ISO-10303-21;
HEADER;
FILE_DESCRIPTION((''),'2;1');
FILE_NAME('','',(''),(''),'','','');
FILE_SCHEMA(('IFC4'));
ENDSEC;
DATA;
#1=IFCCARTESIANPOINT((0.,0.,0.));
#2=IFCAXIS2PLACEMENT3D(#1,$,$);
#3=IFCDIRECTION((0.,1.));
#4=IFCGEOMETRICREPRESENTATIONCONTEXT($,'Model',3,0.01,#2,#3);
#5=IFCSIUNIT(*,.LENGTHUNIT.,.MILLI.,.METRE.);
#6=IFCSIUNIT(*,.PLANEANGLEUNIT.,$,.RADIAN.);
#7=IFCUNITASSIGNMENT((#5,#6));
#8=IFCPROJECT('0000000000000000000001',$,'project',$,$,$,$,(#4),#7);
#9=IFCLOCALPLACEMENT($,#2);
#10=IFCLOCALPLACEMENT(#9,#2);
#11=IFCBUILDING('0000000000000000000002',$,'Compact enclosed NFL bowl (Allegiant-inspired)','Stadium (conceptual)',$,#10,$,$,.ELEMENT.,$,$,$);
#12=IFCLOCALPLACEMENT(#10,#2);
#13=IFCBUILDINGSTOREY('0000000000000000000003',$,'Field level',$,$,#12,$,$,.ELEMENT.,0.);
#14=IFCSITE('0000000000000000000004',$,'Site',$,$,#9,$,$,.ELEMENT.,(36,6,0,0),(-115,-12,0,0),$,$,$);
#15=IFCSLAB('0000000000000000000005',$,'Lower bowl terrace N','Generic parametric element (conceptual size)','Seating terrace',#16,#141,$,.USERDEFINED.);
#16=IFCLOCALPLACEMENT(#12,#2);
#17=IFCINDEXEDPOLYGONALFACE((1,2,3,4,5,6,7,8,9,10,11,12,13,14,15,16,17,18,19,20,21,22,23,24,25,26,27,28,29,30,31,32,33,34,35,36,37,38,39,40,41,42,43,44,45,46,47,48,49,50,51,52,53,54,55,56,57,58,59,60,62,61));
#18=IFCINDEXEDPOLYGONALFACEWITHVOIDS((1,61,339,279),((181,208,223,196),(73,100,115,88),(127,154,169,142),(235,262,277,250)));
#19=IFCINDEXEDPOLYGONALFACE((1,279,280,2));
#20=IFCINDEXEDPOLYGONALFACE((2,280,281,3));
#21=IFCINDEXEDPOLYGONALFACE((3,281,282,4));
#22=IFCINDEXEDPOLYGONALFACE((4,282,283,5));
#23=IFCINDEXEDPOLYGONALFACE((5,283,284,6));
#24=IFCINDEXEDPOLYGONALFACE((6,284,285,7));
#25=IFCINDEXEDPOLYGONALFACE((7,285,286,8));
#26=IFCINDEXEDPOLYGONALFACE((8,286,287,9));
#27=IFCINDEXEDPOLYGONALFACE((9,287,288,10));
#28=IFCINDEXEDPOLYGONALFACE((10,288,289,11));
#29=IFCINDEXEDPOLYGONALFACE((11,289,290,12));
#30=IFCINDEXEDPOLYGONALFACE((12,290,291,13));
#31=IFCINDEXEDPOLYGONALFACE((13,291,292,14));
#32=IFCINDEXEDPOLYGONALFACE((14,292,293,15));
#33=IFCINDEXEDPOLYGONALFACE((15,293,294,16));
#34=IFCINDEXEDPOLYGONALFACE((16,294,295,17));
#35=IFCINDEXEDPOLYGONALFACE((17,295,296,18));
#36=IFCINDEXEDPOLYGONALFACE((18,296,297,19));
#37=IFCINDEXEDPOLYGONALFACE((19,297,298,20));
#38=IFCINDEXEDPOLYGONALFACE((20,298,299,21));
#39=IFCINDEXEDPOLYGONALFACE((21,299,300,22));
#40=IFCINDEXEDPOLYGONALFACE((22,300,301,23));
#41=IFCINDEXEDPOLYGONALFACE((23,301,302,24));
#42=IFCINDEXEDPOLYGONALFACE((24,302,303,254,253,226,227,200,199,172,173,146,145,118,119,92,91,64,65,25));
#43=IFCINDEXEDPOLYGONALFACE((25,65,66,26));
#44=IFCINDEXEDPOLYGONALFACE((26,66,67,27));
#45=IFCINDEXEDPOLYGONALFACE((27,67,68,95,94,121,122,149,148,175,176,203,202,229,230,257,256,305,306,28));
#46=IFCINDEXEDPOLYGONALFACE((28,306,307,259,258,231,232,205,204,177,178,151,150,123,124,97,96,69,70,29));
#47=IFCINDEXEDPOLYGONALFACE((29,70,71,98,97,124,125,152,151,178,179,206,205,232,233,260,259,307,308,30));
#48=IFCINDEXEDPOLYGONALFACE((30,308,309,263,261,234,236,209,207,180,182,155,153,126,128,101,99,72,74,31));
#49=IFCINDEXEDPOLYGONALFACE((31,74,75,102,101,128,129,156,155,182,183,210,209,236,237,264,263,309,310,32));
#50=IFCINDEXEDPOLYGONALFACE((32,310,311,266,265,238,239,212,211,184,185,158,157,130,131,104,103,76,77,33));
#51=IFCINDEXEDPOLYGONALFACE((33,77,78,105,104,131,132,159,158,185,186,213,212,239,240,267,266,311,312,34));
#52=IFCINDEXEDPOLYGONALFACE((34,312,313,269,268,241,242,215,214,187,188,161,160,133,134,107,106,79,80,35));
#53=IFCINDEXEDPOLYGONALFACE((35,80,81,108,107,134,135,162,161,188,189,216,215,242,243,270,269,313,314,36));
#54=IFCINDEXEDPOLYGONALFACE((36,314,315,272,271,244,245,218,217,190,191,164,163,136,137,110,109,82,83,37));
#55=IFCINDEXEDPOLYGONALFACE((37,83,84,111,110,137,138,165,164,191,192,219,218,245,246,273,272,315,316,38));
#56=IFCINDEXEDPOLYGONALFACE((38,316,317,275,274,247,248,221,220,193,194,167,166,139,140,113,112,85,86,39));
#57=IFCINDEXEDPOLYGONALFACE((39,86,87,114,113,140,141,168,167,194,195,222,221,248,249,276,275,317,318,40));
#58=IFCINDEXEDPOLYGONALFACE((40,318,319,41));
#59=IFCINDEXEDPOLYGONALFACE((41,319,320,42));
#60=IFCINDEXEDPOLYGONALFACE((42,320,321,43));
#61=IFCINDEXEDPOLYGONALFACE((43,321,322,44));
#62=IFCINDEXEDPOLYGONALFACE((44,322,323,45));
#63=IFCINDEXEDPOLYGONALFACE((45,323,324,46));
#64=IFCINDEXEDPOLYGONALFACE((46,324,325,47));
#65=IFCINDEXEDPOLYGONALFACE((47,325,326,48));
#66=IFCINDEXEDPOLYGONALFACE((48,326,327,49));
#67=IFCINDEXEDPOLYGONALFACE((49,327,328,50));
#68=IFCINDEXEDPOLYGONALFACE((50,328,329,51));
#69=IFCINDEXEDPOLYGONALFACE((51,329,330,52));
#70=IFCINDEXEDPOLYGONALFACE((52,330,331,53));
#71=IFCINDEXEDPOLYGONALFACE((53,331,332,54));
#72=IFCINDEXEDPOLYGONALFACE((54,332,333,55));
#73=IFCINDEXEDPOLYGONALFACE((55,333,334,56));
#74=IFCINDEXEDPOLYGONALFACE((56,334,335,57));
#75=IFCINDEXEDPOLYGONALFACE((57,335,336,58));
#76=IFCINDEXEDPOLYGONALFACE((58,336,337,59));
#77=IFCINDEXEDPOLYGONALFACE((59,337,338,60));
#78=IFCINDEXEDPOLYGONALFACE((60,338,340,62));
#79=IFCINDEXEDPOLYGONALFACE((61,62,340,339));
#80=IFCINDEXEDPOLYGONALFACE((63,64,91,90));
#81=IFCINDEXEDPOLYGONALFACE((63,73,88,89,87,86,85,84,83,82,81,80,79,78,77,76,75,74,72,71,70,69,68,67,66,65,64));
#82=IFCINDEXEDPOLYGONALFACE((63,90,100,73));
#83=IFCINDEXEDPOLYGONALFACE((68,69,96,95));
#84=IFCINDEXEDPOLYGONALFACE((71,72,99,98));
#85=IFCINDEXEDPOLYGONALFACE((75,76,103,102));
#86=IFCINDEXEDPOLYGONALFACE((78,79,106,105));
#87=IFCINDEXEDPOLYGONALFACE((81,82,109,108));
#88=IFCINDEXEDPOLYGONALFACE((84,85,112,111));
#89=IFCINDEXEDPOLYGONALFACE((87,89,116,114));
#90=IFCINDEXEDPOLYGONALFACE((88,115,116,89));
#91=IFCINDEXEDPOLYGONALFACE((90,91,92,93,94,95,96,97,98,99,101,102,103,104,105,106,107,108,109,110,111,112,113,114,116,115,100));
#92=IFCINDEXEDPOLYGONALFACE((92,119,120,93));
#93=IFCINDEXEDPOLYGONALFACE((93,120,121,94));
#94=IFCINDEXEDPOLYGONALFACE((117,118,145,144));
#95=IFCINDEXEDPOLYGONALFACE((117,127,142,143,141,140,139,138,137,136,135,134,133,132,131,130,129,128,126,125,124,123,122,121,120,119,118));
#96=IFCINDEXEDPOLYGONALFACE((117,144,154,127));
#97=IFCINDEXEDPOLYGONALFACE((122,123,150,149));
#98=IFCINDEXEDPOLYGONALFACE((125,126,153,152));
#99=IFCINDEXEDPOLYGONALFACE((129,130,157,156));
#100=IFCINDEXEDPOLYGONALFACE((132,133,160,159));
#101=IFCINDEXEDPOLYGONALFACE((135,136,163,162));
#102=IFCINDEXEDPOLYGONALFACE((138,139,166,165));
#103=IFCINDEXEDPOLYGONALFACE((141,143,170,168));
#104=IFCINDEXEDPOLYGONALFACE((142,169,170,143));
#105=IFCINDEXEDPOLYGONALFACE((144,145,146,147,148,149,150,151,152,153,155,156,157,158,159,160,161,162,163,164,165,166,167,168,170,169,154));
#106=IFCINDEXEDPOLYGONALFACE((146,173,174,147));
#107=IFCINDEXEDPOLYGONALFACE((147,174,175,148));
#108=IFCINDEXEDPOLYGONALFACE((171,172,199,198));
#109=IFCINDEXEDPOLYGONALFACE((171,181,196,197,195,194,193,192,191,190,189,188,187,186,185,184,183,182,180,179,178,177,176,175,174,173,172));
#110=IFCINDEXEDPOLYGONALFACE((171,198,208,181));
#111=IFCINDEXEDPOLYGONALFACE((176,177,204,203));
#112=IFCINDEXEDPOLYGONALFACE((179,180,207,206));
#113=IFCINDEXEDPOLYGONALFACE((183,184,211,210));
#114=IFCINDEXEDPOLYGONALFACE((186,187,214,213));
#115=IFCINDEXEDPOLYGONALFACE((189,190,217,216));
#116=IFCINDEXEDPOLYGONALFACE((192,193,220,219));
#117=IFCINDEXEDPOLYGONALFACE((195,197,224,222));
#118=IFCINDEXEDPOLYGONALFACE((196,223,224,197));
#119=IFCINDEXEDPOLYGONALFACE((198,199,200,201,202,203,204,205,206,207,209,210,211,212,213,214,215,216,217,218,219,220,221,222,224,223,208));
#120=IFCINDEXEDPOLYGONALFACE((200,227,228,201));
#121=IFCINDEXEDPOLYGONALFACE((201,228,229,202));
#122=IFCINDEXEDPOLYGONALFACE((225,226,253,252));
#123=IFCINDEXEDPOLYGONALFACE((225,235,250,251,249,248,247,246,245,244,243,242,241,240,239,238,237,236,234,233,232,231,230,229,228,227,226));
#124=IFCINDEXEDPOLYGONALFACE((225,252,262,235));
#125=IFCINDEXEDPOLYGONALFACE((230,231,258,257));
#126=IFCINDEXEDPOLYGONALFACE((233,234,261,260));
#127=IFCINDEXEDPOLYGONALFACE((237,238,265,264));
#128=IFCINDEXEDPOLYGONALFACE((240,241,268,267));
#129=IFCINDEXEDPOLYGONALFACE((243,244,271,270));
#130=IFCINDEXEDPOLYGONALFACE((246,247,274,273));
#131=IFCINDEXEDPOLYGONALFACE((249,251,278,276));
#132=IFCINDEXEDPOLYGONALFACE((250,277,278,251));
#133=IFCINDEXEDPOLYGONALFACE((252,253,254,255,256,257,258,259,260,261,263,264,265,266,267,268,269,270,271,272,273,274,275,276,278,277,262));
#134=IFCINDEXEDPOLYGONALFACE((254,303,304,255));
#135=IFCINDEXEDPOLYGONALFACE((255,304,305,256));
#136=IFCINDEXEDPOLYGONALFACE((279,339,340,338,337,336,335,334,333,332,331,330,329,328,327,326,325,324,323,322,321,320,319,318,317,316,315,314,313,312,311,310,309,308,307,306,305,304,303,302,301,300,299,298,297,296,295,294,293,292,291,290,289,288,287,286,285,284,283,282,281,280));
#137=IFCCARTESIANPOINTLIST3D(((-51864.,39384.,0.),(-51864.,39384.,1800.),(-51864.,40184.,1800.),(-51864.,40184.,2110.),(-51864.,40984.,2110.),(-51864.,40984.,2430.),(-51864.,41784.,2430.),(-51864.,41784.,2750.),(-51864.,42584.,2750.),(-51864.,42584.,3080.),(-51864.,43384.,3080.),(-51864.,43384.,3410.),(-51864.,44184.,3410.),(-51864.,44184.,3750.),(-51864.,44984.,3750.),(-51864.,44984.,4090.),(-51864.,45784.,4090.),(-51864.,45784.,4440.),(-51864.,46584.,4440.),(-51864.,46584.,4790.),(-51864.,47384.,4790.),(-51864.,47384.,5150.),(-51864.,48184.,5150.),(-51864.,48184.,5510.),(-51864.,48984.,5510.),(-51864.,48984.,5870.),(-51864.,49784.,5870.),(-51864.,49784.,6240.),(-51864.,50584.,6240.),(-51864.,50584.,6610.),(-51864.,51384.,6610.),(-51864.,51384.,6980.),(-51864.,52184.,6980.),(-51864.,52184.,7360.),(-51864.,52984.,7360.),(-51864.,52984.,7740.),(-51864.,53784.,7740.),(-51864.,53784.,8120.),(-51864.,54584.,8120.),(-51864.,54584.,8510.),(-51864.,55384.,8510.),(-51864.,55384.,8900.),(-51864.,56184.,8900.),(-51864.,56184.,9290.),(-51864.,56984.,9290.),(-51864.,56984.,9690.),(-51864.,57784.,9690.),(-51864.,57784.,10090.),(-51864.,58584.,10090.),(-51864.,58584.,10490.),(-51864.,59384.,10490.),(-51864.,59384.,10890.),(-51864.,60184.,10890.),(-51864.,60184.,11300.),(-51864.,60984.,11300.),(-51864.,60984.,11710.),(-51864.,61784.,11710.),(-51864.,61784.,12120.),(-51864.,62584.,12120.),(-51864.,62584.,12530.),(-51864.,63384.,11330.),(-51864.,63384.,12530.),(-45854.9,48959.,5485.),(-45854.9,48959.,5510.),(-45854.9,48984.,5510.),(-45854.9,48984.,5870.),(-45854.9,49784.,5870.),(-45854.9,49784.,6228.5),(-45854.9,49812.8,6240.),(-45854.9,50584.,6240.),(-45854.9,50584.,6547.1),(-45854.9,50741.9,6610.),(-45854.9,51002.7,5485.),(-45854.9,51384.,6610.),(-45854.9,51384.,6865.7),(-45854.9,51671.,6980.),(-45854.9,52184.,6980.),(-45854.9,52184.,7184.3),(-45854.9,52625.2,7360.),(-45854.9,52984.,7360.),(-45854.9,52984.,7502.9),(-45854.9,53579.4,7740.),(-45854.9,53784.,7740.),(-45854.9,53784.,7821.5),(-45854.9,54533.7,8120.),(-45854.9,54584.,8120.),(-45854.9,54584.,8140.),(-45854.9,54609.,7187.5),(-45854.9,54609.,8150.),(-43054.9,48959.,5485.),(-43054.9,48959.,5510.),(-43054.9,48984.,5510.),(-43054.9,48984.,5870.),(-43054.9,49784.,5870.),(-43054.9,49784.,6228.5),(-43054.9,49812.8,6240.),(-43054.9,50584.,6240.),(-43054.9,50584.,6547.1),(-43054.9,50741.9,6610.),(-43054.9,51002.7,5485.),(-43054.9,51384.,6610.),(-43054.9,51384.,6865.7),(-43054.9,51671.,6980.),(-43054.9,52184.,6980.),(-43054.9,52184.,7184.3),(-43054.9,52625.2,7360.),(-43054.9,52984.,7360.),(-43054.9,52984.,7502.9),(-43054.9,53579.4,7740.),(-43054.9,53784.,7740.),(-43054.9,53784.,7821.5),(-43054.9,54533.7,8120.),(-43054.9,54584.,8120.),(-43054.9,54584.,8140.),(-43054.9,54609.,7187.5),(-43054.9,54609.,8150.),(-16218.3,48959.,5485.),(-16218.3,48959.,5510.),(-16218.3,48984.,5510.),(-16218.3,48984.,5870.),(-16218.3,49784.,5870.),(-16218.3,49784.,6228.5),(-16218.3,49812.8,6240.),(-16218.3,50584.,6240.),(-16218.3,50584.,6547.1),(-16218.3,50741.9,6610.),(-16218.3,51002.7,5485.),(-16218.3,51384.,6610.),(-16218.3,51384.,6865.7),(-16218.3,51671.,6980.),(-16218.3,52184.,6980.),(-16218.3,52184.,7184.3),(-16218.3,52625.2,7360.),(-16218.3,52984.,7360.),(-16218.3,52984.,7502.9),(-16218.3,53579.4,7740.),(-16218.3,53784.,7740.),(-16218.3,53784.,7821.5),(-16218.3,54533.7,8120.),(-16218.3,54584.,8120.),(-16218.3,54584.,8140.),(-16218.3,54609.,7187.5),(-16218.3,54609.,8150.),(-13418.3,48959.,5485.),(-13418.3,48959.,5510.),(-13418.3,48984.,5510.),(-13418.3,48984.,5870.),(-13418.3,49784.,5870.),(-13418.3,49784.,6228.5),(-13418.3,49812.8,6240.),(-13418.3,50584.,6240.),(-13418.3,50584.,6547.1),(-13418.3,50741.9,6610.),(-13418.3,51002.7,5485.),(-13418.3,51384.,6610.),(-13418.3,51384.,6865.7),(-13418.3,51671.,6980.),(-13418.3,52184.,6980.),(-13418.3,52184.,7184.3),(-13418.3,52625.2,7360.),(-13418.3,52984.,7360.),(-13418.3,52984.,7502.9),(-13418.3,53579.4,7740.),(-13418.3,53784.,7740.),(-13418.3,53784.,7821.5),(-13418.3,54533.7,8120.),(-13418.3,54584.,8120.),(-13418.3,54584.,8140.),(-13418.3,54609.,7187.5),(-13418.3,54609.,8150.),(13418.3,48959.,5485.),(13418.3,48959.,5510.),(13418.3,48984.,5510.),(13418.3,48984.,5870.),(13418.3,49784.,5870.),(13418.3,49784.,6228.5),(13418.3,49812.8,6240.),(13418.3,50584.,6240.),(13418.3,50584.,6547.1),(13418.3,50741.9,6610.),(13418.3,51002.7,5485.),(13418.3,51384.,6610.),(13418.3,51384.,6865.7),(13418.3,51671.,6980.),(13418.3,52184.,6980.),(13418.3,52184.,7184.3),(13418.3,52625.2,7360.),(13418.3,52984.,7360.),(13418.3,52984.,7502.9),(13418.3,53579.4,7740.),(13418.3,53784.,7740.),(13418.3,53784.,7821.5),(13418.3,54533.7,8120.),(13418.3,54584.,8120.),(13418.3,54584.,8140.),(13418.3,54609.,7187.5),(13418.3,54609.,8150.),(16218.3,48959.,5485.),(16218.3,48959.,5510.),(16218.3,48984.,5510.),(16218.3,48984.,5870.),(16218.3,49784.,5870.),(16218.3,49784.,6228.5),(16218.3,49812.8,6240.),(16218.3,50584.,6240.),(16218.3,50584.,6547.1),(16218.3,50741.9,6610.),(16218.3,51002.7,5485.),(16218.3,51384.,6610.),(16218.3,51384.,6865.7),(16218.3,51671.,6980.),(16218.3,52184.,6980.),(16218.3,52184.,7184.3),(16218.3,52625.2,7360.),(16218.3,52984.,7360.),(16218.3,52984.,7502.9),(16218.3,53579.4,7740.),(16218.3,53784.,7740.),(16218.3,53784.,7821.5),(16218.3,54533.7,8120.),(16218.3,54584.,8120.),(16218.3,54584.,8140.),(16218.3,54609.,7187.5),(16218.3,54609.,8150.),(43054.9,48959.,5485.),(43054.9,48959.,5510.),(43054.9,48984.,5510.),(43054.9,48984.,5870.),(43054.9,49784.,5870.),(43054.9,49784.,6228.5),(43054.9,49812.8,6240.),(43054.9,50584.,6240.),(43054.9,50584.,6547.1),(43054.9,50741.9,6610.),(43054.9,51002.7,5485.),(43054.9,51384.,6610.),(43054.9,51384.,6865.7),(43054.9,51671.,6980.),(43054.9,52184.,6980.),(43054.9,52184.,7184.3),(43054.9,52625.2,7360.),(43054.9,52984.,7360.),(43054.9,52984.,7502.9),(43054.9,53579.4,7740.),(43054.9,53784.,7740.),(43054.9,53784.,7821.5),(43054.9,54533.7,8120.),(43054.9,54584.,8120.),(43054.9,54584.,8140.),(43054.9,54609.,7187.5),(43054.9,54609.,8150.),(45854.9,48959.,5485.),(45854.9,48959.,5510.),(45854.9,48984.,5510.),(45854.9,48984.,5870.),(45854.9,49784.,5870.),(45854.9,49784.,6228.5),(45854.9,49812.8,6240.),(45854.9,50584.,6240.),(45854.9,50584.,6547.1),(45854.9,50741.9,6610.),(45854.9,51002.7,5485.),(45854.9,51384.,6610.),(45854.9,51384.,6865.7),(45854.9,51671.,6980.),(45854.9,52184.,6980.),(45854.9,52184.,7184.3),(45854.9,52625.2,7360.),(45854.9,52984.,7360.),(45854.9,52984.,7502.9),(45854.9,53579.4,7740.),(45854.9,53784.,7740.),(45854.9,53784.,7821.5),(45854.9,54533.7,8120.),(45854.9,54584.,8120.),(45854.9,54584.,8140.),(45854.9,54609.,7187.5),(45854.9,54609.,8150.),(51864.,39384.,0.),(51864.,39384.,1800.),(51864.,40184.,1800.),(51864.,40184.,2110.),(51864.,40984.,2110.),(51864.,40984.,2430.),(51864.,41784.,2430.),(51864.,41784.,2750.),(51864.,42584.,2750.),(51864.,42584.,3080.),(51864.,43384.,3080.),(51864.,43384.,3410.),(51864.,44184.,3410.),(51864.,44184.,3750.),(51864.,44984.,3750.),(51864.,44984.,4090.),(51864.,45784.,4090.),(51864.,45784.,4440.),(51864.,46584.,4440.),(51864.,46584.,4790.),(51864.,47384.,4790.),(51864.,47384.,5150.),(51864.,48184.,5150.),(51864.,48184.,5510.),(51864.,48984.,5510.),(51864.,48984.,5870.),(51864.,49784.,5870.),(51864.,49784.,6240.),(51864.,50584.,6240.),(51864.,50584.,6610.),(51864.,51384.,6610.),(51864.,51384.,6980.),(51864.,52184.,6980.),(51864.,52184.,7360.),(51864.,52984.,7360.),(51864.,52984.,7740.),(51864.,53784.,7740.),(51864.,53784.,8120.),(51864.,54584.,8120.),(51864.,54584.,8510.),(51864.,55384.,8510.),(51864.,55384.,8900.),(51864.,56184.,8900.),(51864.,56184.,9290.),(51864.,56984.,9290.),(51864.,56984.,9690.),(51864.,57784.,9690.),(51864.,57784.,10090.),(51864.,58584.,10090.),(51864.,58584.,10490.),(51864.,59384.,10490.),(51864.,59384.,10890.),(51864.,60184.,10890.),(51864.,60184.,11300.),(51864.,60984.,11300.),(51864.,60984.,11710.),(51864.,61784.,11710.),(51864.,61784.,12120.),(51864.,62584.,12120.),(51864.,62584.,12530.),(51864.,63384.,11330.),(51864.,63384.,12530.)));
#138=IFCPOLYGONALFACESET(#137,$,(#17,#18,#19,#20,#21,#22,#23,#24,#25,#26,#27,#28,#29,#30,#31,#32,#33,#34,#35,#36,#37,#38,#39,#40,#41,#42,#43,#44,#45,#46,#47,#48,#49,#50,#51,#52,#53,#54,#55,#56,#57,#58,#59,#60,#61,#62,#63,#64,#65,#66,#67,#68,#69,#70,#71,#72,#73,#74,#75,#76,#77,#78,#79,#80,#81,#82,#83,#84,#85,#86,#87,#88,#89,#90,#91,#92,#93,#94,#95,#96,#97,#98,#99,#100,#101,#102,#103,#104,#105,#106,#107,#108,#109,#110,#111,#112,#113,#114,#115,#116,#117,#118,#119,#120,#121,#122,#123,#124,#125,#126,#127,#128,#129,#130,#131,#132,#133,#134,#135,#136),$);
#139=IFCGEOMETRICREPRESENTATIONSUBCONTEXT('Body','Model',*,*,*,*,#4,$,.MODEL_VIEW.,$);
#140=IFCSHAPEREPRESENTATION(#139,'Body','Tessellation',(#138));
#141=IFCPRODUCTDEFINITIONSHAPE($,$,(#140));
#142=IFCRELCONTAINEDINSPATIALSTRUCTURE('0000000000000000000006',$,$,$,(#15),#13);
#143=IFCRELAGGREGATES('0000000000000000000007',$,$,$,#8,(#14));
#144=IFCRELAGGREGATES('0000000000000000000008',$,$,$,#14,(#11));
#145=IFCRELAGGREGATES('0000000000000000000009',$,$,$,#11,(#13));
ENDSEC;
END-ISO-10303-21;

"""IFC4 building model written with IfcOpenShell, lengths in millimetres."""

from ifc_helpers import new_model, si_unit, direction, frame, origin, place, context, subcontext, project, spatial, line, indexed_curve, outline, extrude, element, save


model = new_model("IFC4")

# Units and contexts
model_context = context("Model", 3, precision=0.01, world=origin(), true_north=direction((0.0, 1.0)))
body_context = subcontext(model_context, "Body", "Model", "MODEL_VIEW")
ifc_project = project(units=[si_unit("LENGTHUNIT", "METRE", prefix="MILLI"), si_unit("PLANEANGLEUNIT", "RADIAN")], contexts=[model_context])

# Site, building, storey
site_placement = place(None, origin())
site = spatial("IfcSite", under=ifc_project, at=site_placement, Name="Site", CompositionType="ELEMENT", RefLatitude=(36, 6, 0, 0), RefLongitude=(-115, -12, 0, 0))
building_placement = place(site_placement, origin())
building = spatial("IfcBuilding", under=site, at=building_placement, Name="Compact enclosed NFL bowl (Allegiant-inspired)", Description="Stadium (conceptual)", CompositionType="ELEMENT")
storey_placement = place(building_placement, origin())
storey = spatial("IfcBuildingStorey", under=building, at=storey_placement, Name="Field level", CompositionType="ELEMENT", Elevation=0.0)

# Shared definitions
placement = place(storey_placement, origin())

# Slab, openings
slab_1 = element("IfcSlab", 1, at=placement, inside=storey, Name="Lower bowl terrace N", Description="Generic parametric element (conceptual size)", ObjectType="Seating terrace", PredefinedType="USERDEFINED", context=body_context, shape_type="SweptSolid", body=[
    extrude(outline(indexed_curve([(24000.0, 11330.0), (24000.0, 12530.0), (23200.0, 12530.0), (23200.0, 12120.0), (22400.0, 12120.0), (22400.0, 11710.0), (21600.0, 11710.0), (21600.0, 11300.0), (20800.0, 11300.0), (20800.0, 10890.0), (20000.0, 10890.0), (20000.0, 10490.0), (19200.0, 10490.0), (19200.0, 10090.0), (18400.0, 10090.0), (18400.0, 9690.0), (17600.0, 9690.0), (17600.0, 9290.0), (16800.0, 9290.0), (16800.0, 8900.0), (16000.0, 8900.0), (16000.0, 8510.0), (15200.0, 8510.0), (15200.0, 8120.0), (14400.0, 8120.0), (14400.0, 7740.0), (13600.0, 7740.0), (13600.0, 7360.0), (12800.0, 7360.0), (12800.0, 6980.0), (12000.0, 6980.0), (12000.0, 6610.0), (11200.0, 6610.0), (11200.0, 6240.0), (10400.0, 6240.0), (10400.0, 5870.0), (9600.0, 5870.0), (9600.0, 5510.0), (8800.0, 5510.0), (8800.0, 5150.0), (8000.0, 5150.0), (8000.0, 4790.0), (7200.0, 4790.0), (7200.0, 4440.0), (6400.0, 4440.0), (6400.0, 4090.0), (5600.0, 4090.0), (5600.0, 3750.0), (4800.0, 3750.0), (4800.0, 3410.0), (4000.0, 3410.0), (4000.0, 3080.0), (3200.0, 3080.0), (3200.0, 2750.0), (2400.0, 2750.0), (2400.0, 2430.0), (1600.0, 2430.0), (1600.0, 2110.0), (800.0, 2110.0), (800.0, 1800.0), (0.0, 1800.0), (0.0, 0.0)], segments=[line(1, 2, 3, 4, 5, 6, 7, 8, 9, 10, 11, 12, 13, 14, 15, 16, 17, 18, 19, 20, 21, 22, 23, 24, 25, 26, 27, 28, 29, 30, 31, 32, 33, 34, 35, 36, 37, 38, 39, 40, 41, 42, 43, 44, 45, 46, 47, 48, 49, 50, 51, 52, 53, 54, 55, 56, 57, 58, 59, 60, 61, 62, 1)], self_intersect=False)), frame((-51864.0, 39384.0, 0.0), z_axis=(1.0, 0.0, 0.0), x_axis=(0.0, 1.0, 0.0)), (0.0, 0.0, 1.0), 103728.0),
])
opening_1_placement = place(placement, origin())
element("IfcOpeningElement", 2, at=opening_1_placement, cuts=slab_1, ObjectType="Vomitory", PredefinedType="OPENING", context=body_context, shape_type="SweptSolid", body=[
    extrude(outline(indexed_curve([(9575.0, 5485.0), (15225.0, 5485.0), (15225.0, 8150.0), (9575.0, 5900.0)], segments=[line(1, 2, 3, 4, 1)], self_intersect=False)), frame((43054.9, 39384.0, 0.0), z_axis=(1.0, 0.0, 0.0), x_axis=(0.0, 1.0, 0.0)), (0.0, 0.0, 1.0), 2800.0),
])
opening_2_placement = place(placement, origin())
element("IfcOpeningElement", 3, at=opening_2_placement, cuts=slab_1, ObjectType="Vomitory", PredefinedType="OPENING", context=body_context, shape_type="SweptSolid", body=[
    extrude(outline(indexed_curve([(9575.0, 5485.0), (15225.0, 5485.0), (15225.0, 8150.0), (9575.0, 5900.0)], segments=[line(1, 2, 3, 4, 1)], self_intersect=False)), frame((13418.3, 39384.0, 0.0), z_axis=(1.0, 0.0, 0.0), x_axis=(0.0, 1.0, 0.0)), (0.0, 0.0, 1.0), 2800.0),
])
opening_3_placement = place(placement, origin())
element("IfcOpeningElement", 4, at=opening_3_placement, cuts=slab_1, ObjectType="Vomitory", PredefinedType="OPENING", context=body_context, shape_type="SweptSolid", body=[
    extrude(outline(indexed_curve([(9575.0, 5485.0), (15225.0, 5485.0), (15225.0, 8150.0), (9575.0, 5900.0)], segments=[line(1, 2, 3, 4, 1)], self_intersect=False)), frame((-16218.3, 39384.0, 0.0), z_axis=(1.0, 0.0, 0.0), x_axis=(0.0, 1.0, 0.0)), (0.0, 0.0, 1.0), 2800.0),
])
opening_4_placement = place(placement, origin())
element("IfcOpeningElement", 5, at=opening_4_placement, cuts=slab_1, ObjectType="Vomitory", PredefinedType="OPENING", context=body_context, shape_type="SweptSolid", body=[
    extrude(outline(indexed_curve([(9575.0, 5485.0), (15225.0, 5485.0), (15225.0, 8150.0), (9575.0, 5900.0)], segments=[line(1, 2, 3, 4, 1)], self_intersect=False)), frame((-45854.9, 39384.0, 0.0), z_axis=(1.0, 0.0, 0.0), x_axis=(0.0, 1.0, 0.0)), (0.0, 0.0, 1.0), 2800.0),
])

save(model, "model.ifc")
